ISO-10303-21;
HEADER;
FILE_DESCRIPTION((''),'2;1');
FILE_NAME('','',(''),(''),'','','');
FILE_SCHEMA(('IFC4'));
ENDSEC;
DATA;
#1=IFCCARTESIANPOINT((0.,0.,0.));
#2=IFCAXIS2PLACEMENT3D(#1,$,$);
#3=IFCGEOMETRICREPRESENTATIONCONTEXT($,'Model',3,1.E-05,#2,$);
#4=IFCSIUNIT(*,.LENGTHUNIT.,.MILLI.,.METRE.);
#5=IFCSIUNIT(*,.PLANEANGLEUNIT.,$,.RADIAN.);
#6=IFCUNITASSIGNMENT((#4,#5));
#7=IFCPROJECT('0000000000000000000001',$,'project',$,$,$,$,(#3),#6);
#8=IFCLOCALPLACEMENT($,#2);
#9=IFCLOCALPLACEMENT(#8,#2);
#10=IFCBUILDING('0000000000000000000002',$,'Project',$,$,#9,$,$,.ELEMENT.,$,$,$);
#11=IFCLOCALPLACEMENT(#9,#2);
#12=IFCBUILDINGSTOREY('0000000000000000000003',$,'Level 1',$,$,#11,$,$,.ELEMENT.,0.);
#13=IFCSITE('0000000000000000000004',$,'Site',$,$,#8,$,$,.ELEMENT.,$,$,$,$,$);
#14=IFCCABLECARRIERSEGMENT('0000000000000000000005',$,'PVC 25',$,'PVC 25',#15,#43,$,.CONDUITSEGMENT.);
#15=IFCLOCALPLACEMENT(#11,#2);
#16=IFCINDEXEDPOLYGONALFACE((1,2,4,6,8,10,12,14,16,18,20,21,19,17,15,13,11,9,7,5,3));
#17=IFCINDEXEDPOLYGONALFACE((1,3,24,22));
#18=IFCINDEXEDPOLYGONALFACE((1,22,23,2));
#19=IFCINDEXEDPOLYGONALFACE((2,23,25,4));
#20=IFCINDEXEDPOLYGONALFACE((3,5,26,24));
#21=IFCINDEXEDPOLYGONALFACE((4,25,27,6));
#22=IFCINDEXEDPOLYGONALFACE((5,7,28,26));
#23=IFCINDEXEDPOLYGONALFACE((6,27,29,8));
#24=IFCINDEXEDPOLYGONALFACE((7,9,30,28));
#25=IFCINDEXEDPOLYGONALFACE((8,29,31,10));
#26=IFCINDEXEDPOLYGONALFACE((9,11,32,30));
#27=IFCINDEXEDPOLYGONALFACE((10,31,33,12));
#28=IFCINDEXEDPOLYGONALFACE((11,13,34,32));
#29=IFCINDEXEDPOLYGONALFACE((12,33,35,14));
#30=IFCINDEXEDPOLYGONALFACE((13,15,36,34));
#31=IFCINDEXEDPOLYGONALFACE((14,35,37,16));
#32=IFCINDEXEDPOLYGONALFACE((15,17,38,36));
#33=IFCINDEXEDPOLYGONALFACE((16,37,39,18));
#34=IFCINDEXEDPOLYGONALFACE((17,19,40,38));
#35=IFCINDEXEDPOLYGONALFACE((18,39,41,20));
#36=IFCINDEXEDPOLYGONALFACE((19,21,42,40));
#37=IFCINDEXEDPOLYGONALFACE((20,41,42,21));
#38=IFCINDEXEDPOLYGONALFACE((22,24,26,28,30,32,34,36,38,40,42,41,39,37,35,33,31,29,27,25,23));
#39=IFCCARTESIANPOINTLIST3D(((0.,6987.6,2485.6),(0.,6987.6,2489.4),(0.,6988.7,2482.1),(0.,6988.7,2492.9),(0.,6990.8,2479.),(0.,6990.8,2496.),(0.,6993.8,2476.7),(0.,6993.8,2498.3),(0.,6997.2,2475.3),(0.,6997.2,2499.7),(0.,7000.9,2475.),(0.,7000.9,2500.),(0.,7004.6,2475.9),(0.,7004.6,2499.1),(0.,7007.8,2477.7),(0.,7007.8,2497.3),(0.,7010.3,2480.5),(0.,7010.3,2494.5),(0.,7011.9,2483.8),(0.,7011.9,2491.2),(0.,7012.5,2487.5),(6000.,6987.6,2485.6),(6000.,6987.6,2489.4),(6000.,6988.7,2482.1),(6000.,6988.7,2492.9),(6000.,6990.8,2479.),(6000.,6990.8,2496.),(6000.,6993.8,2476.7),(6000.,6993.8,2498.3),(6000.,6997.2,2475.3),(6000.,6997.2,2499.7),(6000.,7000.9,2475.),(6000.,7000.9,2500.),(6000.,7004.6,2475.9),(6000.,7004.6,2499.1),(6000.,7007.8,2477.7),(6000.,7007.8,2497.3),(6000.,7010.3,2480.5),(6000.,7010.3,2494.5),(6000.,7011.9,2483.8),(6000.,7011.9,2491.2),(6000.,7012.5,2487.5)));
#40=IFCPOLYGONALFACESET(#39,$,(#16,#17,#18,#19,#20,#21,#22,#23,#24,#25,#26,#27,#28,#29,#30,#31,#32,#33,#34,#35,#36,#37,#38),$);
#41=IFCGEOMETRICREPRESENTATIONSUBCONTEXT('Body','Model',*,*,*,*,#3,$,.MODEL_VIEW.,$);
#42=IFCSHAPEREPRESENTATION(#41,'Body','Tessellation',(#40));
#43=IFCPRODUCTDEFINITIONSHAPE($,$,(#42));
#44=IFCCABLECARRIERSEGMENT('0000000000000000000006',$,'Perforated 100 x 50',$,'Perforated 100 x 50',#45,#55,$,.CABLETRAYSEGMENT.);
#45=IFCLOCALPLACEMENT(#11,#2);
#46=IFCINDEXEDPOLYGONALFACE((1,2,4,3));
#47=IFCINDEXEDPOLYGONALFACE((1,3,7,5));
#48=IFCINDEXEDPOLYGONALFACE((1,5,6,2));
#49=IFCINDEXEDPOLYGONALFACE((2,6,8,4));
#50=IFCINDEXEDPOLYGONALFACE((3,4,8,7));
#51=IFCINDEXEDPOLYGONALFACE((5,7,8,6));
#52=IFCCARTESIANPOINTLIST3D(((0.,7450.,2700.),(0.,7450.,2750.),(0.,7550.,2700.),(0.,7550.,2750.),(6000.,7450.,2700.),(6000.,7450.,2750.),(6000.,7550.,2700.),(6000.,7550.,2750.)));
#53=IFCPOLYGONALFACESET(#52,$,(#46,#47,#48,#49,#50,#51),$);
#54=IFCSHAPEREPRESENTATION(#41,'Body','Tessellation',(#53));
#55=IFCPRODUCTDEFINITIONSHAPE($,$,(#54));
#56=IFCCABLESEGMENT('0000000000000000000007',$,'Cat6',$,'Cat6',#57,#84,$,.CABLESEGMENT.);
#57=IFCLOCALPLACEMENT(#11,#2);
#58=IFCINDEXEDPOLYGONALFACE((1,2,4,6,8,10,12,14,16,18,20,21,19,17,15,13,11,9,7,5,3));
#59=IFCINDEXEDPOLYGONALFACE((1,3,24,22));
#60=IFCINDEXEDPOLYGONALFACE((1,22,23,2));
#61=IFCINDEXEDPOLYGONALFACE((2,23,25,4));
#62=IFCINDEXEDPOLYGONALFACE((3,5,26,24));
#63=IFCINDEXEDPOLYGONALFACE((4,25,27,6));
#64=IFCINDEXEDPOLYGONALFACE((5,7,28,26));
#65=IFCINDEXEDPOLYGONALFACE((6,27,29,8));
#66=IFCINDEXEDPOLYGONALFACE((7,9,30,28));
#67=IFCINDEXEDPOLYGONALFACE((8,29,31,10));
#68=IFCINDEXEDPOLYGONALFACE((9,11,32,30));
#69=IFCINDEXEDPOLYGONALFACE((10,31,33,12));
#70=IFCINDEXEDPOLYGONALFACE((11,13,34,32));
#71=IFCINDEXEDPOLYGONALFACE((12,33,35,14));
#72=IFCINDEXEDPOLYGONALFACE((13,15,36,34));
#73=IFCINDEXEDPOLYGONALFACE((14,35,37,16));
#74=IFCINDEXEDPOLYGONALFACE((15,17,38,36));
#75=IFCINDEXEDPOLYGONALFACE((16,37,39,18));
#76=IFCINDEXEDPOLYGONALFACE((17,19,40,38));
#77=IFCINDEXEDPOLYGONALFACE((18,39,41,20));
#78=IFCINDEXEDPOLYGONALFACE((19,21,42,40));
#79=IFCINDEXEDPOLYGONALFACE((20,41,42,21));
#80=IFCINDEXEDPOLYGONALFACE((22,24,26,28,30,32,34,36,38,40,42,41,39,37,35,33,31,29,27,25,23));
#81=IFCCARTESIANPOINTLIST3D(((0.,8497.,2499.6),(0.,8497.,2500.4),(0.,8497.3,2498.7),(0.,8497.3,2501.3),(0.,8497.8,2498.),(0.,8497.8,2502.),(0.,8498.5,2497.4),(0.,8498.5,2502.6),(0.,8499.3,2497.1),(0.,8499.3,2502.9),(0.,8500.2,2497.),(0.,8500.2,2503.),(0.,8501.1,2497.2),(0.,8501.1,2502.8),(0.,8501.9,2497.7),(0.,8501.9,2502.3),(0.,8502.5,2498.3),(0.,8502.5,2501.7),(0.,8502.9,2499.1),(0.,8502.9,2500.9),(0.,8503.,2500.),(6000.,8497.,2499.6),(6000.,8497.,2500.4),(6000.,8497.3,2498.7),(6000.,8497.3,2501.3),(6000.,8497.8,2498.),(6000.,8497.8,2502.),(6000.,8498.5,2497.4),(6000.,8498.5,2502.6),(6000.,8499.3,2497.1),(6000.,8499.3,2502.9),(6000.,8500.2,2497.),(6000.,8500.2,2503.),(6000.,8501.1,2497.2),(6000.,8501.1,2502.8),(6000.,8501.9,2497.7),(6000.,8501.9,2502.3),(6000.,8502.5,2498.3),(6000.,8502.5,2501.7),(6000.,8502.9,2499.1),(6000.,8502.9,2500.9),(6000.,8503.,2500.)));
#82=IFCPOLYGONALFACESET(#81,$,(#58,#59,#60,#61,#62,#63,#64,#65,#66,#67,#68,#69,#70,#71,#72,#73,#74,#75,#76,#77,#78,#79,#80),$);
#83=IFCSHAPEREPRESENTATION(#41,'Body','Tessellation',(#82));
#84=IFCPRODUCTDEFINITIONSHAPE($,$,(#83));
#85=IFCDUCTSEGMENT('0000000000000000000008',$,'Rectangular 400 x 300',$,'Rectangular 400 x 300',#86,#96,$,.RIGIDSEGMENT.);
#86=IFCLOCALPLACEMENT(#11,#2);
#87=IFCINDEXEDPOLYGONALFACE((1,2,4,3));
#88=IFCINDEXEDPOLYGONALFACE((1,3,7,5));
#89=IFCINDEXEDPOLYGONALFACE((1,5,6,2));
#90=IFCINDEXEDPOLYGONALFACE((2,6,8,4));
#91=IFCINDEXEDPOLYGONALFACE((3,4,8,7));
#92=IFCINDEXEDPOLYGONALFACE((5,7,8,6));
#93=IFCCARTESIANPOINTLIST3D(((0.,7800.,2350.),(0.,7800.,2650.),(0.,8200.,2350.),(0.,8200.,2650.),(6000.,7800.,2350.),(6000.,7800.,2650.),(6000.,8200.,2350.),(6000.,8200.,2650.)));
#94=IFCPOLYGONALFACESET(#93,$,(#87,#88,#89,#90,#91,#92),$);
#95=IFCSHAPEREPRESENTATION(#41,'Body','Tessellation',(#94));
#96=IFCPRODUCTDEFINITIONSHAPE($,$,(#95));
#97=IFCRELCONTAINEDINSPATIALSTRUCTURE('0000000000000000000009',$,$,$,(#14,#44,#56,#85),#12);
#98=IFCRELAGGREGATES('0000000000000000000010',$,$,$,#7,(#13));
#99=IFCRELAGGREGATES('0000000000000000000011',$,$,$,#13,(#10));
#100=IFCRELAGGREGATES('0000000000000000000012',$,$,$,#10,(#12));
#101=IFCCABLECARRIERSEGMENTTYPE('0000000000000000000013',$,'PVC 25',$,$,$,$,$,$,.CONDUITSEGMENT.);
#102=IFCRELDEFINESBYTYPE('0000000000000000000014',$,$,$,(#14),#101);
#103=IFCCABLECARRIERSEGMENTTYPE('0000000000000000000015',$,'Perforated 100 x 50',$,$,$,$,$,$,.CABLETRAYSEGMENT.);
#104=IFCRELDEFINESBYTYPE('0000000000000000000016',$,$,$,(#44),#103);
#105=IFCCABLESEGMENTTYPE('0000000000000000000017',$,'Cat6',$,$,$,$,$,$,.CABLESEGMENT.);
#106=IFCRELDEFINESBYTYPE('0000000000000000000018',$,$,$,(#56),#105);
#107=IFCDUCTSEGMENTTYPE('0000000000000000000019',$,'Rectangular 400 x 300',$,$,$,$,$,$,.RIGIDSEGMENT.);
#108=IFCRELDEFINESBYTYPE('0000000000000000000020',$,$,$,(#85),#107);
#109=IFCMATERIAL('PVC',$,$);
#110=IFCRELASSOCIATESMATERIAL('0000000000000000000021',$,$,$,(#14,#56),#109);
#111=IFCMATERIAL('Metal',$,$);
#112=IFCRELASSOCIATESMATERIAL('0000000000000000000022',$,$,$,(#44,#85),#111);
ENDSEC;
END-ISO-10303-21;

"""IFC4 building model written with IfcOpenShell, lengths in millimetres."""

from ifc_helpers import new_model, si_unit, frame, origin, origin_2d, place, context, subcontext, project, spatial, rectangle, circle, extrude, material, type_object, element, save


model = new_model("IFC4")

# Units and contexts
model_context = context("Model", 3, precision=1e-05, world=origin())
body_context = subcontext(model_context, "Body", "Model", "MODEL_VIEW")
ifc_project = project(units=[si_unit("LENGTHUNIT", "METRE", prefix="MILLI"), si_unit("PLANEANGLEUNIT", "RADIAN")], contexts=[model_context])

# Site, building, storey
site_placement = place(None, origin())
site = spatial("IfcSite", under=ifc_project, at=site_placement, Name="Site", CompositionType="ELEMENT")
building_placement = place(site_placement, origin())
building = spatial("IfcBuilding", under=site, at=building_placement, Name="Project", CompositionType="ELEMENT")
storey_placement = place(building_placement, origin())
storey = spatial("IfcBuildingStorey", under=building, at=storey_placement, Name="Level 1", CompositionType="ELEMENT", Elevation=0.0)

# Shared definitions
ifc_material_1 = material(Name="Metal")

# Cable carrier segments
ifc_material_2 = material(Name="PVC")
cable_carrier_segment_type_1 = type_object("IfcCableCarrierSegmentType", Name="PVC 25", PredefinedType="CONDUITSEGMENT")
cable_carrier_segment_1_placement = place(storey_placement, frame((0.0, 7000.0, 2487.5)))
element("IfcCableCarrierSegment", 1, at=cable_carrier_segment_1_placement, inside=storey, type_object=cable_carrier_segment_type_1, material=ifc_material_2, Name="PVC 25", ObjectType="PVC 25", PredefinedType="CONDUITSEGMENT", context=body_context, shape_type="SweptSolid", body=[
    extrude(circle(Radius=12.5, at=origin_2d()), frame((0.0, 0.0, 0.0), z_axis=(1.0, 0.0, 0.0), x_axis=(0.0, 1.0, 0.0)), (0.0, 0.0, 1.0), 6000.0),
])
cable_carrier_segment_type_2 = type_object("IfcCableCarrierSegmentType", Name="Perforated 100 x 50", PredefinedType="CABLETRAYSEGMENT")
cable_carrier_segment_2_placement = place(storey_placement, frame((0.0, 7500.0, 2725.0)))
element("IfcCableCarrierSegment", 2, at=cable_carrier_segment_2_placement, inside=storey, type_object=cable_carrier_segment_type_2, material=ifc_material_1, Name="Perforated 100 x 50", ObjectType="Perforated 100 x 50", PredefinedType="CABLETRAYSEGMENT", context=body_context, shape_type="SweptSolid", body=[
    extrude(rectangle(XDim=100.0, YDim=50.0, at=origin_2d()), frame((0.0, 0.0, 0.0), z_axis=(1.0, 0.0, 0.0), x_axis=(0.0, 1.0, 0.0)), (0.0, 0.0, 1.0), 6000.0),
])

# Cable segment
cable_segment_type = type_object("IfcCableSegmentType", Name="Cat6", PredefinedType="CABLESEGMENT")
cable_segment_placement = place(storey_placement, frame((0.0, 8500.0, 2500.0)))
element("IfcCableSegment", 3, at=cable_segment_placement, inside=storey, type_object=cable_segment_type, material=ifc_material_2, Name="Cat6", ObjectType="Cat6", PredefinedType="CABLESEGMENT", context=body_context, shape_type="SweptSolid", body=[
    extrude(circle(Radius=3.0, at=origin_2d()), frame((0.0, 0.0, 0.0), z_axis=(1.0, 0.0, 0.0), x_axis=(0.0, 1.0, 0.0)), (0.0, 0.0, 1.0), 6000.0),
])

# Duct segment
duct_segment_type = type_object("IfcDuctSegmentType", Name="Rectangular 400 x 300", PredefinedType="RIGIDSEGMENT")
duct_segment_placement = place(storey_placement, frame((0.0, 8000.0, 2500.0)))
element("IfcDuctSegment", 4, at=duct_segment_placement, inside=storey, type_object=duct_segment_type, material=ifc_material_1, Name="Rectangular 400 x 300", ObjectType="Rectangular 400 x 300", PredefinedType="RIGIDSEGMENT", context=body_context, shape_type="SweptSolid", body=[
    extrude(rectangle(XDim=400.0, YDim=300.0, at=origin_2d()), frame((0.0, 0.0, 0.0), z_axis=(1.0, 0.0, 0.0), x_axis=(0.0, 1.0, 0.0)), (0.0, 0.0, 1.0), 6000.0),
])

save(model, "model.ifc")
